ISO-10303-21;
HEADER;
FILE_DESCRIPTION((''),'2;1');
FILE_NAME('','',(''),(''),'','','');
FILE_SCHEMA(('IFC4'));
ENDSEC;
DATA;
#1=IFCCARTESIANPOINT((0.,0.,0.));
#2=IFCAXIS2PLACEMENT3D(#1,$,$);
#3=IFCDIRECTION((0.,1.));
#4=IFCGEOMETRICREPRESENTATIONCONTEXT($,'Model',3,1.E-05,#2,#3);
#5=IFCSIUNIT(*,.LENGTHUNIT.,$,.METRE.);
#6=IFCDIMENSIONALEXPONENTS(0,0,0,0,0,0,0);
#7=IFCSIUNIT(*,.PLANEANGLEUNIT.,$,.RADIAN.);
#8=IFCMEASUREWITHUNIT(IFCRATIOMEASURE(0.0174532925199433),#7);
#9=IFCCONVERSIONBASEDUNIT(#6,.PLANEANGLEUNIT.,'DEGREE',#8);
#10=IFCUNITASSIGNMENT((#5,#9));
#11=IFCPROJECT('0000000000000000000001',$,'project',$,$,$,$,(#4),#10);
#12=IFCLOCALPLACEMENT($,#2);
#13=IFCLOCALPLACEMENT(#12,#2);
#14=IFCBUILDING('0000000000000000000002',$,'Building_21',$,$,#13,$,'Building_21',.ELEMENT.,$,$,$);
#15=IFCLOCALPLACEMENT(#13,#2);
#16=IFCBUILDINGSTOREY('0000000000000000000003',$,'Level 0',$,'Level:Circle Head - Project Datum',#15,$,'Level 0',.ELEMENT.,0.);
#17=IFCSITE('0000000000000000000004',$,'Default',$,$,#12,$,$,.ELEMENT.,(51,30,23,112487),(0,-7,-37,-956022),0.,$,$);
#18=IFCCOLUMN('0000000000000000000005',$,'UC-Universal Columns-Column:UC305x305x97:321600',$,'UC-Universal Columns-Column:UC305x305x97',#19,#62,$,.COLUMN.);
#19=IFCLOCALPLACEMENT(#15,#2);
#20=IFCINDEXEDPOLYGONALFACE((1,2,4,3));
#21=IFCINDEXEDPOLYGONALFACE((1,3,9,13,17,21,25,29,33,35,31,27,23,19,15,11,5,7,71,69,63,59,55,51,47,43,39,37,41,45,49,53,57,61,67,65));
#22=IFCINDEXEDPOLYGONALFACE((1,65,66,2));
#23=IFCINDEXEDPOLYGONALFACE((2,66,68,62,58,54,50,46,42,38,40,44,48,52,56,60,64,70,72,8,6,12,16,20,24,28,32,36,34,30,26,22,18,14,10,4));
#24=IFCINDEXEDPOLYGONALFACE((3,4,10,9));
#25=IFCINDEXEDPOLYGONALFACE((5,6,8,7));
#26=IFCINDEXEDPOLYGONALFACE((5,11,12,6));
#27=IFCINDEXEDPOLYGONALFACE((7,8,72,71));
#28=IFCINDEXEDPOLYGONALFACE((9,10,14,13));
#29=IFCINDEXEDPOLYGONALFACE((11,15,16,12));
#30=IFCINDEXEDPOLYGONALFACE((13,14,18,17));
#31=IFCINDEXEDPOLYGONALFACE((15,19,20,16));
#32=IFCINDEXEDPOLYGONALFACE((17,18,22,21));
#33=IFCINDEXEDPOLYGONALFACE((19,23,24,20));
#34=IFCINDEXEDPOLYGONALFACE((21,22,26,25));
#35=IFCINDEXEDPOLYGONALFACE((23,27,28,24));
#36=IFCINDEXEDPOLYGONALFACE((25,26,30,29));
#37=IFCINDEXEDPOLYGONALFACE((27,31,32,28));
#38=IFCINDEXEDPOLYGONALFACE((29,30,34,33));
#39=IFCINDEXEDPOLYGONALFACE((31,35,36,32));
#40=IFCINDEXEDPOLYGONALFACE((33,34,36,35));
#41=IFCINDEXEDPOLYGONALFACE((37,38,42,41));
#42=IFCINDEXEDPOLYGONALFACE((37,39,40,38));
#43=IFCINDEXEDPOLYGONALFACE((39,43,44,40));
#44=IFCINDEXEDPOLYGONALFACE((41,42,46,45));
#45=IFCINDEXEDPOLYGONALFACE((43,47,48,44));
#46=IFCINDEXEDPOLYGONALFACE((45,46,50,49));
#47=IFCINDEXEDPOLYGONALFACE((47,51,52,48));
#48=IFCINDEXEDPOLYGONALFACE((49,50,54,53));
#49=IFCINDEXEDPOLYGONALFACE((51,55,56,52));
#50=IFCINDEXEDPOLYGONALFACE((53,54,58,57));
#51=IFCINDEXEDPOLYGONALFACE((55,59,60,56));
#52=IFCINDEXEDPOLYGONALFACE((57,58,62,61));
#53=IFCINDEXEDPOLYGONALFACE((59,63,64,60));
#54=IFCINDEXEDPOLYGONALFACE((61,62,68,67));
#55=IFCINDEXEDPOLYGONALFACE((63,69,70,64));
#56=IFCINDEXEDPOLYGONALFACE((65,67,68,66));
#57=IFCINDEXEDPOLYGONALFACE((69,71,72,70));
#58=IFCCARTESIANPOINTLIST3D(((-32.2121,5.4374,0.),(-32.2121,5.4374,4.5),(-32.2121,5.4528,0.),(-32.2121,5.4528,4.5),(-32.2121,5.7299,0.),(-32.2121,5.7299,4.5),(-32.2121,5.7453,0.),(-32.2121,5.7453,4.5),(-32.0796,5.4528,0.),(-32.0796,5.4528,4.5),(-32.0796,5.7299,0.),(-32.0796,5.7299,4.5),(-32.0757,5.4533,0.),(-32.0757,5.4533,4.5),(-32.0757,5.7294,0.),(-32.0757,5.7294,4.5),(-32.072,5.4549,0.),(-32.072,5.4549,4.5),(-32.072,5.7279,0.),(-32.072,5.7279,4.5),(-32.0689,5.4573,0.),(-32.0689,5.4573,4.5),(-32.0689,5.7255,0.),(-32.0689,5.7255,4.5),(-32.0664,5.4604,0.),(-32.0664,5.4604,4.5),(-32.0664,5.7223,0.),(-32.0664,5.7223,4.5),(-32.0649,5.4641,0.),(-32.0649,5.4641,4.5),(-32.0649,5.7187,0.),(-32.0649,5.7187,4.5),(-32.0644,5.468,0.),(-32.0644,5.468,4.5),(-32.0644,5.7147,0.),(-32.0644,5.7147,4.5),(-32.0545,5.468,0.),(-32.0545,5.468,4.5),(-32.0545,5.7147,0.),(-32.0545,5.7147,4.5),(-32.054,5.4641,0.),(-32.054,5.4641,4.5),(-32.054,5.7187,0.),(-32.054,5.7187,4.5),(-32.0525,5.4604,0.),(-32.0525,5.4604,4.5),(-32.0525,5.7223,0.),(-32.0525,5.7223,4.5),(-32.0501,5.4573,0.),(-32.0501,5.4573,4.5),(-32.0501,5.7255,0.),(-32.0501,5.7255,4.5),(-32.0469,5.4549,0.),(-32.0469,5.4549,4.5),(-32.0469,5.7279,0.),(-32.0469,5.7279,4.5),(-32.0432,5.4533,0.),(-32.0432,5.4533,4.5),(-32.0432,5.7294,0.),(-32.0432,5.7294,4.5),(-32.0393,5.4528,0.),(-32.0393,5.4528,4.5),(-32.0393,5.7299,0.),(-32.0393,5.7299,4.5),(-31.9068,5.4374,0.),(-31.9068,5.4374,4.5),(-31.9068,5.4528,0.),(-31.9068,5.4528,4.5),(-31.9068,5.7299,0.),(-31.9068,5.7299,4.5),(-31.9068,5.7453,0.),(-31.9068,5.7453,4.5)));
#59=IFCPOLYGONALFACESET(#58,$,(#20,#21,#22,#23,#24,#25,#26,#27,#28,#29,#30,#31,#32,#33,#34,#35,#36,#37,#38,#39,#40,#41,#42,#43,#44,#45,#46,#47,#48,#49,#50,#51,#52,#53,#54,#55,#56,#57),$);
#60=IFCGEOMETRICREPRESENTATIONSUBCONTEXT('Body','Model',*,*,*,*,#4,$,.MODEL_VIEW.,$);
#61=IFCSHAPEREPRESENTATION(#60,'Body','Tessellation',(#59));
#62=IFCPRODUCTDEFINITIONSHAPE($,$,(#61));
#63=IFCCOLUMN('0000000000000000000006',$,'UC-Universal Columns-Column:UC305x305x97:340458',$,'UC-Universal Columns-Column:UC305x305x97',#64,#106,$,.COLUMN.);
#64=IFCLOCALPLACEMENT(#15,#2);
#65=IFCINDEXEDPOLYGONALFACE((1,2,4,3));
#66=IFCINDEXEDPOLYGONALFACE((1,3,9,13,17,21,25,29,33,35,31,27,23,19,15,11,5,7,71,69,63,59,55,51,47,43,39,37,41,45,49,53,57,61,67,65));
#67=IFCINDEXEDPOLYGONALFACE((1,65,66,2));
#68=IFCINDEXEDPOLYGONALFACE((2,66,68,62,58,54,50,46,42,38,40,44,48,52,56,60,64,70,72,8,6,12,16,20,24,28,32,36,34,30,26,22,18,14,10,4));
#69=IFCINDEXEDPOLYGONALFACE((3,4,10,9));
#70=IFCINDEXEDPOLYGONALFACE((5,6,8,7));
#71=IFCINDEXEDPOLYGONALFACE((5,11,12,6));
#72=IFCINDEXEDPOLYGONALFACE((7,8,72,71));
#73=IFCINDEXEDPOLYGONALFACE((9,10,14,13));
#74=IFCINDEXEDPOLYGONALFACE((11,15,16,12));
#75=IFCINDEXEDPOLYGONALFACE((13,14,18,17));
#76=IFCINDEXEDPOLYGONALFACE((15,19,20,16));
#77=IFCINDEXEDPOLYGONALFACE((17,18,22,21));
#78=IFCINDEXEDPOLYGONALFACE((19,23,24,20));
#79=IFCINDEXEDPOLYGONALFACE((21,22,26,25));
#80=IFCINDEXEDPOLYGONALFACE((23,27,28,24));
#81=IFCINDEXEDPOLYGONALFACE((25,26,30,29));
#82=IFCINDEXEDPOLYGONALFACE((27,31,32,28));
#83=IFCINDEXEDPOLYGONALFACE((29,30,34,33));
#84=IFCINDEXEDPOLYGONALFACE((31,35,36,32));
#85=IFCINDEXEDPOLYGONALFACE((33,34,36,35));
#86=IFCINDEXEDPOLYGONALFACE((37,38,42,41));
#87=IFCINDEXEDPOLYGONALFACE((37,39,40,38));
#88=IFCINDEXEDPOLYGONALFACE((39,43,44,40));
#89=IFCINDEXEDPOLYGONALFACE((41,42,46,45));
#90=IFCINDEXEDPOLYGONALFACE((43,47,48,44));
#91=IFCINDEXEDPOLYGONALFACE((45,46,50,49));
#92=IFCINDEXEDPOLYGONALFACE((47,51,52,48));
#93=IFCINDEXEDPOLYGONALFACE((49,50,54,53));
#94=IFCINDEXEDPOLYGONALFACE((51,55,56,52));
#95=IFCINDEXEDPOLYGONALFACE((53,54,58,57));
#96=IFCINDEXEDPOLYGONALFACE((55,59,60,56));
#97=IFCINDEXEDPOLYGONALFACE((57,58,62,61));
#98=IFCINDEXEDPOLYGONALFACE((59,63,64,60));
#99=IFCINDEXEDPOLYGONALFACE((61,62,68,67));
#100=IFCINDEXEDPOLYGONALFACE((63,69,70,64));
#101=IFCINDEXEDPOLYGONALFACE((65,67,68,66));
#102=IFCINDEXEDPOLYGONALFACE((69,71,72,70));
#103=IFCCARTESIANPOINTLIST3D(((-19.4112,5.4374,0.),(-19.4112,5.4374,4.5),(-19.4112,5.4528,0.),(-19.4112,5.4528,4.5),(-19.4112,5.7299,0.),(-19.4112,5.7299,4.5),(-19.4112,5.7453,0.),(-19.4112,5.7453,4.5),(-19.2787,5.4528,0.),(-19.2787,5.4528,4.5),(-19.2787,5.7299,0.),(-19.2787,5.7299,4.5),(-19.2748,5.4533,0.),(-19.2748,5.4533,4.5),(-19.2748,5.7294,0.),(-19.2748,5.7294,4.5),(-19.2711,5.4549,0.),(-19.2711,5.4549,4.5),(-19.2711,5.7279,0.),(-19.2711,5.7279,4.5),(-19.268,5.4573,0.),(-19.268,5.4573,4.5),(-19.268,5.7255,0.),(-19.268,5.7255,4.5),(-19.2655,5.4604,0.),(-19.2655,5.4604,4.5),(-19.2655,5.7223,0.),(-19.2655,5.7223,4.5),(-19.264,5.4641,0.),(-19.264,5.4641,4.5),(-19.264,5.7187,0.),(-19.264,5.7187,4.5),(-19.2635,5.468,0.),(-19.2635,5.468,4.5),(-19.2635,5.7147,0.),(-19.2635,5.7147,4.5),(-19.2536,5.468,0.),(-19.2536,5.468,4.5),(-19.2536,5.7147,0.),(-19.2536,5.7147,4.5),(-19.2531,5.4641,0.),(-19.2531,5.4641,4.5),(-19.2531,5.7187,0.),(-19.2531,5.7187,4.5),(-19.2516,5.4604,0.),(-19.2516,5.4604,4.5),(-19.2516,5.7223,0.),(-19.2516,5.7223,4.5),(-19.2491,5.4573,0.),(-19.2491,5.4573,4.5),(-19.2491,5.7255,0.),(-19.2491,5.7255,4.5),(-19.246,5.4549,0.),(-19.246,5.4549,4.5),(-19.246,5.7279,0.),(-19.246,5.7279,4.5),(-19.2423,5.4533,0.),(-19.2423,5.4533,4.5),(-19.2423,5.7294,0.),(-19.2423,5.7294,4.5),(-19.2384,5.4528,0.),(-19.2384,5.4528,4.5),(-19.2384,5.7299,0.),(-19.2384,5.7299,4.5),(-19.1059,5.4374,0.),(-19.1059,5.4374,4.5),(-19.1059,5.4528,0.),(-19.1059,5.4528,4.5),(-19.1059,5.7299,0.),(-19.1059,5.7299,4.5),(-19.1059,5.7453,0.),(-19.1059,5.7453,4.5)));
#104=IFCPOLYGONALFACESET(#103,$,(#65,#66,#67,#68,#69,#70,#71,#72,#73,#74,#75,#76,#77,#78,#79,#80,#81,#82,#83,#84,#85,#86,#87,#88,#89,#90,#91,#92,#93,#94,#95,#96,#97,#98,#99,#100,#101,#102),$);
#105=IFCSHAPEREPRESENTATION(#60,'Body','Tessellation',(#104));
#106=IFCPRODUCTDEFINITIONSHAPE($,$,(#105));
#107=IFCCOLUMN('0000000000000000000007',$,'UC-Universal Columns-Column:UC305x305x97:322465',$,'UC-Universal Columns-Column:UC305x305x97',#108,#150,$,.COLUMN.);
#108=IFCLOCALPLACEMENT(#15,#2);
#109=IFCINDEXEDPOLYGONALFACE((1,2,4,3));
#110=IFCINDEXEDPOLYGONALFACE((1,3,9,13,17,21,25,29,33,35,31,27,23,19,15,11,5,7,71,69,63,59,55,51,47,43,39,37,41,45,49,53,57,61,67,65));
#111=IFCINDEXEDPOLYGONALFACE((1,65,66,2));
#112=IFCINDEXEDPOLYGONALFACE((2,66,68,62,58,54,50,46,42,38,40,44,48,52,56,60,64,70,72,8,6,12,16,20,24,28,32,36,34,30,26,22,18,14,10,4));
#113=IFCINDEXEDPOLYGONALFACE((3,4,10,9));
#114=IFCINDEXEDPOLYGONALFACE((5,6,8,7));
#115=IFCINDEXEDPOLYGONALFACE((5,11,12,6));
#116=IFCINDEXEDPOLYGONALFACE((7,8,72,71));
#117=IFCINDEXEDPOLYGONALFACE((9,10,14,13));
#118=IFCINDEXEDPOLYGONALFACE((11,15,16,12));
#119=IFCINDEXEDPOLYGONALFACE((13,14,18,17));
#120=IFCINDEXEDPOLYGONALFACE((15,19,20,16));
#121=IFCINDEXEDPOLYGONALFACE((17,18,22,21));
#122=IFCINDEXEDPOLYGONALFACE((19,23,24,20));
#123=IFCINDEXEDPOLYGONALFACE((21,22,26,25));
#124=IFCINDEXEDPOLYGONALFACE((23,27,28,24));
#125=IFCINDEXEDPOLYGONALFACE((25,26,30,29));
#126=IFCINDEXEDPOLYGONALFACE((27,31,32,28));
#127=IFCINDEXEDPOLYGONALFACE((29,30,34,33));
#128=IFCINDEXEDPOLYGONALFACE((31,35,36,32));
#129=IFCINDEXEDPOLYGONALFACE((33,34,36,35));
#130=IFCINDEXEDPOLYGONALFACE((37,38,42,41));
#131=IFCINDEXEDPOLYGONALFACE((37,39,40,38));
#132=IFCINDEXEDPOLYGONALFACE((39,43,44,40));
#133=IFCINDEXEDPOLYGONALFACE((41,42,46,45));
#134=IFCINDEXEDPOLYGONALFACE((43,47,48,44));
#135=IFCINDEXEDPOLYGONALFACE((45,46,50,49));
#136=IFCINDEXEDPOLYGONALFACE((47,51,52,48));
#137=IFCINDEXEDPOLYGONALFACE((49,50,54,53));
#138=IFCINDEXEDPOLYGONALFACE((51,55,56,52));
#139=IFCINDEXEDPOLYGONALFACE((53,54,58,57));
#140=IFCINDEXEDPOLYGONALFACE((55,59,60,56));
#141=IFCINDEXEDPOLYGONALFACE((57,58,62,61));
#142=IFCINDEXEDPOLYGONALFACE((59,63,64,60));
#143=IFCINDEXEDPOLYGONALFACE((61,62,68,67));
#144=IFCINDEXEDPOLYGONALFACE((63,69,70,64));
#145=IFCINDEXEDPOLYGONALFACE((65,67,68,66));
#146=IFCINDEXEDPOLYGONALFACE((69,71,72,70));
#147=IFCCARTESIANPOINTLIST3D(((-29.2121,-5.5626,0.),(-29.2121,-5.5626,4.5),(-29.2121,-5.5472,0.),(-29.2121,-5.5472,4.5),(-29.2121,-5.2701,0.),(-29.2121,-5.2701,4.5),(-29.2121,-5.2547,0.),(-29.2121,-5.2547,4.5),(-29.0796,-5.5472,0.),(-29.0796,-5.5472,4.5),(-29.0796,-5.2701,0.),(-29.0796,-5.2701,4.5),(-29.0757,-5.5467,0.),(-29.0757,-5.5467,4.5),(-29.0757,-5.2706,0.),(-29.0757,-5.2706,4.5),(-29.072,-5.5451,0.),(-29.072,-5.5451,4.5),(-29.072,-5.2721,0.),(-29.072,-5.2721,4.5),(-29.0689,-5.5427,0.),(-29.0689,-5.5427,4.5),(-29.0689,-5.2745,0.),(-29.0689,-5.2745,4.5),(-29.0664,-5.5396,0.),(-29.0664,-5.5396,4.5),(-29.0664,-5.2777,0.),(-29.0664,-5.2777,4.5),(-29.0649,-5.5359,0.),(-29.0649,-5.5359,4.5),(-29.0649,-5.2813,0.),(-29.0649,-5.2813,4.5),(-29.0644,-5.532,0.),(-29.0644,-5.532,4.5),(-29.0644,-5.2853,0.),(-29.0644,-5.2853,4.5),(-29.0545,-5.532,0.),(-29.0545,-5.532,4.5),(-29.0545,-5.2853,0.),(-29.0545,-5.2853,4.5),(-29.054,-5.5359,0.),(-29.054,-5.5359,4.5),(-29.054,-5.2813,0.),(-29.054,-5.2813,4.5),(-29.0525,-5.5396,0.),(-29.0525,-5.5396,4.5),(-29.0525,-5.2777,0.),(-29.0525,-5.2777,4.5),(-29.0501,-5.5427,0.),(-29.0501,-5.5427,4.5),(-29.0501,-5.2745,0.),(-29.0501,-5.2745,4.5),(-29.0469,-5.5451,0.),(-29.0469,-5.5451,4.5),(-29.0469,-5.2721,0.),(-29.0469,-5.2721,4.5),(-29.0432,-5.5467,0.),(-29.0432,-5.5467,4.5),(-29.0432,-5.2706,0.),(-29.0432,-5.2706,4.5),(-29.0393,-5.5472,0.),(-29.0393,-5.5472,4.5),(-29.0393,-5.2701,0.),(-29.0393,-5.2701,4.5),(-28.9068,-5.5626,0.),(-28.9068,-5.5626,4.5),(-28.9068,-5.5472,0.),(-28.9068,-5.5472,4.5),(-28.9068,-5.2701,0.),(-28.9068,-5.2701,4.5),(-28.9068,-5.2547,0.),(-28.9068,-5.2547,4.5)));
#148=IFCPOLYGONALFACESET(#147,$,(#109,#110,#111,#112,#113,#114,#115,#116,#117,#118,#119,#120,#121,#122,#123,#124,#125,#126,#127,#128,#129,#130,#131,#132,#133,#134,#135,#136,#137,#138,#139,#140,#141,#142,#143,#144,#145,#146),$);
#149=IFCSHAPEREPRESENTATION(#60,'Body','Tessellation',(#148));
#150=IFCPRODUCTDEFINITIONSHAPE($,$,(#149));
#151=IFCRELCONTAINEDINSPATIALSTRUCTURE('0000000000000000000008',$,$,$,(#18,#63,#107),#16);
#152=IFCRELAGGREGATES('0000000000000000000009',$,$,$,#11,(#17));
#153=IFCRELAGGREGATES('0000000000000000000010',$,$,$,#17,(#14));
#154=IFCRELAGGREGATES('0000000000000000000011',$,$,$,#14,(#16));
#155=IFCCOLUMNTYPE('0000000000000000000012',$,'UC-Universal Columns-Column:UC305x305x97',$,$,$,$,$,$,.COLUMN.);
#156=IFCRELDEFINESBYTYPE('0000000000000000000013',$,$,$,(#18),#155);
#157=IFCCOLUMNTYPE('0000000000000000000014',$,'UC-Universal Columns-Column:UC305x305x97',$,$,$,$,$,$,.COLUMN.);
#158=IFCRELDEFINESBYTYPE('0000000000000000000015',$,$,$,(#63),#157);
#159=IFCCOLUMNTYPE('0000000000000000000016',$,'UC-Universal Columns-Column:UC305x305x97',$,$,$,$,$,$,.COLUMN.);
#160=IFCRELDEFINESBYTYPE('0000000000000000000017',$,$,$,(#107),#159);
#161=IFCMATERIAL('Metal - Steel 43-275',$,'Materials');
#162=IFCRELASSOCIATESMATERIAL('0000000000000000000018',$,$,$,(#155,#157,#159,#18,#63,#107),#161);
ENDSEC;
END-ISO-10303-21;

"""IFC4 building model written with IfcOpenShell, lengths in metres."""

from ifc_helpers import new_model, entity, si_unit, converted_unit, direction, frame, frame_2d, origin, place, context, subcontext, project, spatial, polyline, circle_curve, parameter, trimmed, segment, composite_curve, i_section, outline, extrude, source, transform, mapped, material, material_profile, profile_set, profile_usage, type_object, type_shapes, element, save


model = new_model("IFC4")

# Units and contexts
model_context = context("Model", 3, precision=1e-05, world=origin(), true_north=direction((0.0, 1.0)))
body_context = subcontext(model_context, "Body", "Model", "MODEL_VIEW")
ifc_project = project(units=[si_unit("LENGTHUNIT", "METRE"), converted_unit("PLANEANGLEUNIT", "DEGREE", entity("IfcRatioMeasure", 0.0174532925199433), si_unit("PLANEANGLEUNIT", "RADIAN"), dimensions=[0, 0, 0, 0, 0, 0, 0])], contexts=[model_context])

# Site, building, storey
site_placement = place(None, origin())
site = spatial("IfcSite", under=ifc_project, at=site_placement, Name="Default", CompositionType="ELEMENT", RefLatitude=(51, 30, 23, 112487), RefLongitude=(0, -7, -37, -956022), RefElevation=0.0)
building_placement = place(site_placement, origin())
building = spatial("IfcBuilding", under=site, at=building_placement, Name="Building_21", LongName="Building_21", CompositionType="ELEMENT")
storey_placement = place(building_placement, origin())
storey = spatial("IfcBuildingStorey", under=building, at=storey_placement, Name="Level 0", ObjectType="Level:Circle Head - Project Datum", LongName="Level 0", CompositionType="ELEMENT", Elevation=0.0)

# Columns
ifc_material_1 = material(Name="Metal - Steel 43-275", Category="Materials")
ifc_material_profile_1 = material_profile(ifc_material_1, outline(composite_curve([segment(polyline([(-0.1527, 0.154, 0.0), (0.1527, 0.154, 0.0)]), True, "CONTINUOUS"), segment(polyline([(0.1527, 0.154, 0.0), (0.1527, 0.1386, 0.0)]), True, "CONTINUOUS"), segment(polyline([(0.1527, 0.1386, 0.0), (0.0201, 0.1386, 0.0)]), True, "CONTINUOUS"), segment(trimmed(circle_curve(frame((0.0201, 0.1234, 0.0)), 0.0152), [parameter(90.0)], [parameter(180.0)], True, "PARAMETER"), True, "CONTINUOUS"), segment(polyline([(0.0049, 0.1234, 0.0), (0.0049, -0.1234, 0.0)]), True, "CONTINUOUS"), segment(trimmed(circle_curve(frame((0.0201, -0.1234, 0.0)), 0.0152), [parameter(180.0)], [parameter(270.0)], True, "PARAMETER"), True, "CONTINUOUS"), segment(polyline([(0.0201, -0.1386, 0.0), (0.1527, -0.1386, 0.0)]), True, "CONTINUOUS"), segment(polyline([(0.1527, -0.1386, 0.0), (0.1527, -0.154, 0.0)]), True, "CONTINUOUS"), segment(polyline([(0.1527, -0.154, 0.0), (-0.1527, -0.154, 0.0)]), True, "CONTINUOUS"), segment(polyline([(-0.1527, -0.154, 0.0), (-0.1527, -0.1386, 0.0)]), True, "CONTINUOUS"), segment(polyline([(-0.1527, -0.1386, 0.0), (-0.0201, -0.1386, 0.0)]), True, "CONTINUOUS"), segment(trimmed(circle_curve(frame((-0.0201, -0.1234, 0.0)), 0.0152), [parameter(270.0)], [parameter(0.0)], True, "PARAMETER"), True, "CONTINUOUS"), segment(polyline([(-0.0049, -0.1234, 0.0), (-0.005, 0.1234, 0.0)]), True, "CONTINUOUS"), segment(trimmed(circle_curve(frame((-0.0201, 0.1234, 0.0)), 0.0152), [parameter(0.0)], [parameter(90.0)], True, "PARAMETER"), True, "CONTINUOUS"), segment(polyline([(-0.0201, 0.1386, 0.0), (-0.1527, 0.1386, 0.0)]), True, "CONTINUOUS"), segment(polyline([(-0.1527, 0.1386, 0.0), (-0.1527, 0.154, 0.0)]), True, "CONTINUOUS")], self_intersect=False), kind="CURVE"), Name="UC305x305x97")
ifc_material_profile_2 = material_profile(ifc_material_1, outline(composite_curve([segment(polyline([(0.1527, 0.154, 0.0), (0.1527, 0.1386, 0.0)]), True, "CONTINUOUS"), segment(polyline([(0.1527, 0.1386, 0.0), (0.0049, 0.1386, 0.0)]), True, "CONTINUOUS"), segment(polyline([(0.0049, 0.1386, 0.0), (0.0049, -0.1386, 0.0)]), True, "CONTINUOUS"), segment(polyline([(0.0049, -0.1386, 0.0), (0.1527, -0.1386, 0.0)]), True, "CONTINUOUS"), segment(polyline([(0.1527, -0.1386, 0.0), (0.1527, -0.154, 0.0)]), True, "CONTINUOUS"), segment(polyline([(0.1527, -0.154, 0.0), (-0.1527, -0.154, 0.0)]), True, "CONTINUOUS"), segment(polyline([(-0.1527, -0.154, 0.0), (-0.1527, -0.1386, 0.0)]), True, "CONTINUOUS"), segment(polyline([(-0.1527, -0.1386, 0.0), (-0.005, -0.1386, 0.0)]), True, "CONTINUOUS"), segment(polyline([(-0.005, -0.1386, 0.0), (-0.005, 0.1386, 0.0)]), True, "CONTINUOUS"), segment(polyline([(-0.005, 0.1386, 0.0), (-0.1527, 0.1386, 0.0)]), True, "CONTINUOUS"), segment(polyline([(-0.1527, 0.1386, 0.0), (-0.1527, 0.154, 0.0)]), True, "CONTINUOUS"), segment(polyline([(-0.1527, 0.154, 0.0), (0.1527, 0.154, 0.0)]), True, "CONTINUOUS")], self_intersect=False), kind="CURVE"), Name="UC305x305x97")
ifc_profile_set = profile_set([ifc_material_profile_1, ifc_material_profile_2], Name="UC305x305x97")
ifc_profile_usage_1 = profile_usage(ifc_profile_set)
column_type_1 = type_object("IfcColumnType", Name="UC-Universal Columns-Column:UC305x305x97", PredefinedType="COLUMN", material=ifc_profile_set)
shared_shape_1 = source(origin(), body_context, "Body", "SweptSolid", [
    extrude(i_section(OverallWidth=0.3053, OverallDepth=0.3079, WebThickness=0.0099, FlangeThickness=0.0154, FilletRadius=0.0152, at=frame_2d((0.0, 0.0), x_axis=(0.0, 1.0))), frame((-32.0595, 5.5914, 0.0), z_axis=(0.0, 0.0, 1.0), x_axis=(0.0, -1.0, 0.0)), (0.0, 0.0, 1.0), 4.5),
])
type_shapes(column_type_1, [shared_shape_1])
column_1_placement = place(storey_placement, origin())
element("IfcColumn", 1, at=column_1_placement, inside=storey, type_object=column_type_1, material=ifc_profile_usage_1, Name="UC-Universal Columns-Column:UC305x305x97:321600", ObjectType="UC-Universal Columns-Column:UC305x305x97", PredefinedType="COLUMN", context=body_context, shape_type="MappedRepresentation", body=[
    mapped(shared_shape_1, transform((0.0, 0.0, 0.0), scale=1.0)),
])
ifc_profile_usage_2 = profile_usage(ifc_profile_set)
column_type_2 = type_object("IfcColumnType", Name="UC-Universal Columns-Column:UC305x305x97", PredefinedType="COLUMN", material=ifc_profile_set)
shared_shape_2 = source(origin(), body_context, "Body", "SweptSolid", [
    extrude(i_section(OverallWidth=0.3053, OverallDepth=0.3079, WebThickness=0.0099, FlangeThickness=0.0154, FilletRadius=0.0152, at=frame_2d((0.0, 0.0), x_axis=(0.0, 1.0))), frame((0.0, 0.0, 0.0), z_axis=(0.0, 0.0, 1.0), x_axis=(0.0, -1.0, 0.0)), (0.0, 0.0, 1.0), 4.5),
])
type_shapes(column_type_2, [shared_shape_2])
column_2_placement = place(storey_placement, frame((-19.2586, 5.5914, 0.0)))
element("IfcColumn", 2, at=column_2_placement, inside=storey, type_object=column_type_2, material=ifc_profile_usage_2, Name="UC-Universal Columns-Column:UC305x305x97:340458", ObjectType="UC-Universal Columns-Column:UC305x305x97", PredefinedType="COLUMN", context=body_context, shape_type="MappedRepresentation", body=[
    mapped(shared_shape_2, transform((0.0, 0.0, 0.0), scale=1.0)),
])
ifc_profile_usage_3 = profile_usage(ifc_profile_set)
column_type_3 = type_object("IfcColumnType", Name="UC-Universal Columns-Column:UC305x305x97", PredefinedType="COLUMN", material=ifc_profile_set)
shared_shape_3 = source(origin(), body_context, "Body", "SweptSolid", [
    extrude(i_section(OverallWidth=0.3053, OverallDepth=0.3079, WebThickness=0.0099, FlangeThickness=0.0154, FilletRadius=0.0152, at=frame_2d((0.0, 0.0), x_axis=(0.0, 1.0))), frame((-29.0595, -5.4086, 0.0), z_axis=(0.0, 0.0, 1.0), x_axis=(0.0, -1.0, 0.0)), (0.0, 0.0, 1.0), 4.5),
])
type_shapes(column_type_3, [shared_shape_3])
column_3_placement = place(storey_placement, origin())
element("IfcColumn", 3, at=column_3_placement, inside=storey, type_object=column_type_3, material=ifc_profile_usage_3, Name="UC-Universal Columns-Column:UC305x305x97:322465", ObjectType="UC-Universal Columns-Column:UC305x305x97", PredefinedType="COLUMN", context=body_context, shape_type="MappedRepresentation", body=[
    mapped(shared_shape_3, transform((0.0, 0.0, 0.0), scale=1.0)),
])

save(model, "model.ifc")
